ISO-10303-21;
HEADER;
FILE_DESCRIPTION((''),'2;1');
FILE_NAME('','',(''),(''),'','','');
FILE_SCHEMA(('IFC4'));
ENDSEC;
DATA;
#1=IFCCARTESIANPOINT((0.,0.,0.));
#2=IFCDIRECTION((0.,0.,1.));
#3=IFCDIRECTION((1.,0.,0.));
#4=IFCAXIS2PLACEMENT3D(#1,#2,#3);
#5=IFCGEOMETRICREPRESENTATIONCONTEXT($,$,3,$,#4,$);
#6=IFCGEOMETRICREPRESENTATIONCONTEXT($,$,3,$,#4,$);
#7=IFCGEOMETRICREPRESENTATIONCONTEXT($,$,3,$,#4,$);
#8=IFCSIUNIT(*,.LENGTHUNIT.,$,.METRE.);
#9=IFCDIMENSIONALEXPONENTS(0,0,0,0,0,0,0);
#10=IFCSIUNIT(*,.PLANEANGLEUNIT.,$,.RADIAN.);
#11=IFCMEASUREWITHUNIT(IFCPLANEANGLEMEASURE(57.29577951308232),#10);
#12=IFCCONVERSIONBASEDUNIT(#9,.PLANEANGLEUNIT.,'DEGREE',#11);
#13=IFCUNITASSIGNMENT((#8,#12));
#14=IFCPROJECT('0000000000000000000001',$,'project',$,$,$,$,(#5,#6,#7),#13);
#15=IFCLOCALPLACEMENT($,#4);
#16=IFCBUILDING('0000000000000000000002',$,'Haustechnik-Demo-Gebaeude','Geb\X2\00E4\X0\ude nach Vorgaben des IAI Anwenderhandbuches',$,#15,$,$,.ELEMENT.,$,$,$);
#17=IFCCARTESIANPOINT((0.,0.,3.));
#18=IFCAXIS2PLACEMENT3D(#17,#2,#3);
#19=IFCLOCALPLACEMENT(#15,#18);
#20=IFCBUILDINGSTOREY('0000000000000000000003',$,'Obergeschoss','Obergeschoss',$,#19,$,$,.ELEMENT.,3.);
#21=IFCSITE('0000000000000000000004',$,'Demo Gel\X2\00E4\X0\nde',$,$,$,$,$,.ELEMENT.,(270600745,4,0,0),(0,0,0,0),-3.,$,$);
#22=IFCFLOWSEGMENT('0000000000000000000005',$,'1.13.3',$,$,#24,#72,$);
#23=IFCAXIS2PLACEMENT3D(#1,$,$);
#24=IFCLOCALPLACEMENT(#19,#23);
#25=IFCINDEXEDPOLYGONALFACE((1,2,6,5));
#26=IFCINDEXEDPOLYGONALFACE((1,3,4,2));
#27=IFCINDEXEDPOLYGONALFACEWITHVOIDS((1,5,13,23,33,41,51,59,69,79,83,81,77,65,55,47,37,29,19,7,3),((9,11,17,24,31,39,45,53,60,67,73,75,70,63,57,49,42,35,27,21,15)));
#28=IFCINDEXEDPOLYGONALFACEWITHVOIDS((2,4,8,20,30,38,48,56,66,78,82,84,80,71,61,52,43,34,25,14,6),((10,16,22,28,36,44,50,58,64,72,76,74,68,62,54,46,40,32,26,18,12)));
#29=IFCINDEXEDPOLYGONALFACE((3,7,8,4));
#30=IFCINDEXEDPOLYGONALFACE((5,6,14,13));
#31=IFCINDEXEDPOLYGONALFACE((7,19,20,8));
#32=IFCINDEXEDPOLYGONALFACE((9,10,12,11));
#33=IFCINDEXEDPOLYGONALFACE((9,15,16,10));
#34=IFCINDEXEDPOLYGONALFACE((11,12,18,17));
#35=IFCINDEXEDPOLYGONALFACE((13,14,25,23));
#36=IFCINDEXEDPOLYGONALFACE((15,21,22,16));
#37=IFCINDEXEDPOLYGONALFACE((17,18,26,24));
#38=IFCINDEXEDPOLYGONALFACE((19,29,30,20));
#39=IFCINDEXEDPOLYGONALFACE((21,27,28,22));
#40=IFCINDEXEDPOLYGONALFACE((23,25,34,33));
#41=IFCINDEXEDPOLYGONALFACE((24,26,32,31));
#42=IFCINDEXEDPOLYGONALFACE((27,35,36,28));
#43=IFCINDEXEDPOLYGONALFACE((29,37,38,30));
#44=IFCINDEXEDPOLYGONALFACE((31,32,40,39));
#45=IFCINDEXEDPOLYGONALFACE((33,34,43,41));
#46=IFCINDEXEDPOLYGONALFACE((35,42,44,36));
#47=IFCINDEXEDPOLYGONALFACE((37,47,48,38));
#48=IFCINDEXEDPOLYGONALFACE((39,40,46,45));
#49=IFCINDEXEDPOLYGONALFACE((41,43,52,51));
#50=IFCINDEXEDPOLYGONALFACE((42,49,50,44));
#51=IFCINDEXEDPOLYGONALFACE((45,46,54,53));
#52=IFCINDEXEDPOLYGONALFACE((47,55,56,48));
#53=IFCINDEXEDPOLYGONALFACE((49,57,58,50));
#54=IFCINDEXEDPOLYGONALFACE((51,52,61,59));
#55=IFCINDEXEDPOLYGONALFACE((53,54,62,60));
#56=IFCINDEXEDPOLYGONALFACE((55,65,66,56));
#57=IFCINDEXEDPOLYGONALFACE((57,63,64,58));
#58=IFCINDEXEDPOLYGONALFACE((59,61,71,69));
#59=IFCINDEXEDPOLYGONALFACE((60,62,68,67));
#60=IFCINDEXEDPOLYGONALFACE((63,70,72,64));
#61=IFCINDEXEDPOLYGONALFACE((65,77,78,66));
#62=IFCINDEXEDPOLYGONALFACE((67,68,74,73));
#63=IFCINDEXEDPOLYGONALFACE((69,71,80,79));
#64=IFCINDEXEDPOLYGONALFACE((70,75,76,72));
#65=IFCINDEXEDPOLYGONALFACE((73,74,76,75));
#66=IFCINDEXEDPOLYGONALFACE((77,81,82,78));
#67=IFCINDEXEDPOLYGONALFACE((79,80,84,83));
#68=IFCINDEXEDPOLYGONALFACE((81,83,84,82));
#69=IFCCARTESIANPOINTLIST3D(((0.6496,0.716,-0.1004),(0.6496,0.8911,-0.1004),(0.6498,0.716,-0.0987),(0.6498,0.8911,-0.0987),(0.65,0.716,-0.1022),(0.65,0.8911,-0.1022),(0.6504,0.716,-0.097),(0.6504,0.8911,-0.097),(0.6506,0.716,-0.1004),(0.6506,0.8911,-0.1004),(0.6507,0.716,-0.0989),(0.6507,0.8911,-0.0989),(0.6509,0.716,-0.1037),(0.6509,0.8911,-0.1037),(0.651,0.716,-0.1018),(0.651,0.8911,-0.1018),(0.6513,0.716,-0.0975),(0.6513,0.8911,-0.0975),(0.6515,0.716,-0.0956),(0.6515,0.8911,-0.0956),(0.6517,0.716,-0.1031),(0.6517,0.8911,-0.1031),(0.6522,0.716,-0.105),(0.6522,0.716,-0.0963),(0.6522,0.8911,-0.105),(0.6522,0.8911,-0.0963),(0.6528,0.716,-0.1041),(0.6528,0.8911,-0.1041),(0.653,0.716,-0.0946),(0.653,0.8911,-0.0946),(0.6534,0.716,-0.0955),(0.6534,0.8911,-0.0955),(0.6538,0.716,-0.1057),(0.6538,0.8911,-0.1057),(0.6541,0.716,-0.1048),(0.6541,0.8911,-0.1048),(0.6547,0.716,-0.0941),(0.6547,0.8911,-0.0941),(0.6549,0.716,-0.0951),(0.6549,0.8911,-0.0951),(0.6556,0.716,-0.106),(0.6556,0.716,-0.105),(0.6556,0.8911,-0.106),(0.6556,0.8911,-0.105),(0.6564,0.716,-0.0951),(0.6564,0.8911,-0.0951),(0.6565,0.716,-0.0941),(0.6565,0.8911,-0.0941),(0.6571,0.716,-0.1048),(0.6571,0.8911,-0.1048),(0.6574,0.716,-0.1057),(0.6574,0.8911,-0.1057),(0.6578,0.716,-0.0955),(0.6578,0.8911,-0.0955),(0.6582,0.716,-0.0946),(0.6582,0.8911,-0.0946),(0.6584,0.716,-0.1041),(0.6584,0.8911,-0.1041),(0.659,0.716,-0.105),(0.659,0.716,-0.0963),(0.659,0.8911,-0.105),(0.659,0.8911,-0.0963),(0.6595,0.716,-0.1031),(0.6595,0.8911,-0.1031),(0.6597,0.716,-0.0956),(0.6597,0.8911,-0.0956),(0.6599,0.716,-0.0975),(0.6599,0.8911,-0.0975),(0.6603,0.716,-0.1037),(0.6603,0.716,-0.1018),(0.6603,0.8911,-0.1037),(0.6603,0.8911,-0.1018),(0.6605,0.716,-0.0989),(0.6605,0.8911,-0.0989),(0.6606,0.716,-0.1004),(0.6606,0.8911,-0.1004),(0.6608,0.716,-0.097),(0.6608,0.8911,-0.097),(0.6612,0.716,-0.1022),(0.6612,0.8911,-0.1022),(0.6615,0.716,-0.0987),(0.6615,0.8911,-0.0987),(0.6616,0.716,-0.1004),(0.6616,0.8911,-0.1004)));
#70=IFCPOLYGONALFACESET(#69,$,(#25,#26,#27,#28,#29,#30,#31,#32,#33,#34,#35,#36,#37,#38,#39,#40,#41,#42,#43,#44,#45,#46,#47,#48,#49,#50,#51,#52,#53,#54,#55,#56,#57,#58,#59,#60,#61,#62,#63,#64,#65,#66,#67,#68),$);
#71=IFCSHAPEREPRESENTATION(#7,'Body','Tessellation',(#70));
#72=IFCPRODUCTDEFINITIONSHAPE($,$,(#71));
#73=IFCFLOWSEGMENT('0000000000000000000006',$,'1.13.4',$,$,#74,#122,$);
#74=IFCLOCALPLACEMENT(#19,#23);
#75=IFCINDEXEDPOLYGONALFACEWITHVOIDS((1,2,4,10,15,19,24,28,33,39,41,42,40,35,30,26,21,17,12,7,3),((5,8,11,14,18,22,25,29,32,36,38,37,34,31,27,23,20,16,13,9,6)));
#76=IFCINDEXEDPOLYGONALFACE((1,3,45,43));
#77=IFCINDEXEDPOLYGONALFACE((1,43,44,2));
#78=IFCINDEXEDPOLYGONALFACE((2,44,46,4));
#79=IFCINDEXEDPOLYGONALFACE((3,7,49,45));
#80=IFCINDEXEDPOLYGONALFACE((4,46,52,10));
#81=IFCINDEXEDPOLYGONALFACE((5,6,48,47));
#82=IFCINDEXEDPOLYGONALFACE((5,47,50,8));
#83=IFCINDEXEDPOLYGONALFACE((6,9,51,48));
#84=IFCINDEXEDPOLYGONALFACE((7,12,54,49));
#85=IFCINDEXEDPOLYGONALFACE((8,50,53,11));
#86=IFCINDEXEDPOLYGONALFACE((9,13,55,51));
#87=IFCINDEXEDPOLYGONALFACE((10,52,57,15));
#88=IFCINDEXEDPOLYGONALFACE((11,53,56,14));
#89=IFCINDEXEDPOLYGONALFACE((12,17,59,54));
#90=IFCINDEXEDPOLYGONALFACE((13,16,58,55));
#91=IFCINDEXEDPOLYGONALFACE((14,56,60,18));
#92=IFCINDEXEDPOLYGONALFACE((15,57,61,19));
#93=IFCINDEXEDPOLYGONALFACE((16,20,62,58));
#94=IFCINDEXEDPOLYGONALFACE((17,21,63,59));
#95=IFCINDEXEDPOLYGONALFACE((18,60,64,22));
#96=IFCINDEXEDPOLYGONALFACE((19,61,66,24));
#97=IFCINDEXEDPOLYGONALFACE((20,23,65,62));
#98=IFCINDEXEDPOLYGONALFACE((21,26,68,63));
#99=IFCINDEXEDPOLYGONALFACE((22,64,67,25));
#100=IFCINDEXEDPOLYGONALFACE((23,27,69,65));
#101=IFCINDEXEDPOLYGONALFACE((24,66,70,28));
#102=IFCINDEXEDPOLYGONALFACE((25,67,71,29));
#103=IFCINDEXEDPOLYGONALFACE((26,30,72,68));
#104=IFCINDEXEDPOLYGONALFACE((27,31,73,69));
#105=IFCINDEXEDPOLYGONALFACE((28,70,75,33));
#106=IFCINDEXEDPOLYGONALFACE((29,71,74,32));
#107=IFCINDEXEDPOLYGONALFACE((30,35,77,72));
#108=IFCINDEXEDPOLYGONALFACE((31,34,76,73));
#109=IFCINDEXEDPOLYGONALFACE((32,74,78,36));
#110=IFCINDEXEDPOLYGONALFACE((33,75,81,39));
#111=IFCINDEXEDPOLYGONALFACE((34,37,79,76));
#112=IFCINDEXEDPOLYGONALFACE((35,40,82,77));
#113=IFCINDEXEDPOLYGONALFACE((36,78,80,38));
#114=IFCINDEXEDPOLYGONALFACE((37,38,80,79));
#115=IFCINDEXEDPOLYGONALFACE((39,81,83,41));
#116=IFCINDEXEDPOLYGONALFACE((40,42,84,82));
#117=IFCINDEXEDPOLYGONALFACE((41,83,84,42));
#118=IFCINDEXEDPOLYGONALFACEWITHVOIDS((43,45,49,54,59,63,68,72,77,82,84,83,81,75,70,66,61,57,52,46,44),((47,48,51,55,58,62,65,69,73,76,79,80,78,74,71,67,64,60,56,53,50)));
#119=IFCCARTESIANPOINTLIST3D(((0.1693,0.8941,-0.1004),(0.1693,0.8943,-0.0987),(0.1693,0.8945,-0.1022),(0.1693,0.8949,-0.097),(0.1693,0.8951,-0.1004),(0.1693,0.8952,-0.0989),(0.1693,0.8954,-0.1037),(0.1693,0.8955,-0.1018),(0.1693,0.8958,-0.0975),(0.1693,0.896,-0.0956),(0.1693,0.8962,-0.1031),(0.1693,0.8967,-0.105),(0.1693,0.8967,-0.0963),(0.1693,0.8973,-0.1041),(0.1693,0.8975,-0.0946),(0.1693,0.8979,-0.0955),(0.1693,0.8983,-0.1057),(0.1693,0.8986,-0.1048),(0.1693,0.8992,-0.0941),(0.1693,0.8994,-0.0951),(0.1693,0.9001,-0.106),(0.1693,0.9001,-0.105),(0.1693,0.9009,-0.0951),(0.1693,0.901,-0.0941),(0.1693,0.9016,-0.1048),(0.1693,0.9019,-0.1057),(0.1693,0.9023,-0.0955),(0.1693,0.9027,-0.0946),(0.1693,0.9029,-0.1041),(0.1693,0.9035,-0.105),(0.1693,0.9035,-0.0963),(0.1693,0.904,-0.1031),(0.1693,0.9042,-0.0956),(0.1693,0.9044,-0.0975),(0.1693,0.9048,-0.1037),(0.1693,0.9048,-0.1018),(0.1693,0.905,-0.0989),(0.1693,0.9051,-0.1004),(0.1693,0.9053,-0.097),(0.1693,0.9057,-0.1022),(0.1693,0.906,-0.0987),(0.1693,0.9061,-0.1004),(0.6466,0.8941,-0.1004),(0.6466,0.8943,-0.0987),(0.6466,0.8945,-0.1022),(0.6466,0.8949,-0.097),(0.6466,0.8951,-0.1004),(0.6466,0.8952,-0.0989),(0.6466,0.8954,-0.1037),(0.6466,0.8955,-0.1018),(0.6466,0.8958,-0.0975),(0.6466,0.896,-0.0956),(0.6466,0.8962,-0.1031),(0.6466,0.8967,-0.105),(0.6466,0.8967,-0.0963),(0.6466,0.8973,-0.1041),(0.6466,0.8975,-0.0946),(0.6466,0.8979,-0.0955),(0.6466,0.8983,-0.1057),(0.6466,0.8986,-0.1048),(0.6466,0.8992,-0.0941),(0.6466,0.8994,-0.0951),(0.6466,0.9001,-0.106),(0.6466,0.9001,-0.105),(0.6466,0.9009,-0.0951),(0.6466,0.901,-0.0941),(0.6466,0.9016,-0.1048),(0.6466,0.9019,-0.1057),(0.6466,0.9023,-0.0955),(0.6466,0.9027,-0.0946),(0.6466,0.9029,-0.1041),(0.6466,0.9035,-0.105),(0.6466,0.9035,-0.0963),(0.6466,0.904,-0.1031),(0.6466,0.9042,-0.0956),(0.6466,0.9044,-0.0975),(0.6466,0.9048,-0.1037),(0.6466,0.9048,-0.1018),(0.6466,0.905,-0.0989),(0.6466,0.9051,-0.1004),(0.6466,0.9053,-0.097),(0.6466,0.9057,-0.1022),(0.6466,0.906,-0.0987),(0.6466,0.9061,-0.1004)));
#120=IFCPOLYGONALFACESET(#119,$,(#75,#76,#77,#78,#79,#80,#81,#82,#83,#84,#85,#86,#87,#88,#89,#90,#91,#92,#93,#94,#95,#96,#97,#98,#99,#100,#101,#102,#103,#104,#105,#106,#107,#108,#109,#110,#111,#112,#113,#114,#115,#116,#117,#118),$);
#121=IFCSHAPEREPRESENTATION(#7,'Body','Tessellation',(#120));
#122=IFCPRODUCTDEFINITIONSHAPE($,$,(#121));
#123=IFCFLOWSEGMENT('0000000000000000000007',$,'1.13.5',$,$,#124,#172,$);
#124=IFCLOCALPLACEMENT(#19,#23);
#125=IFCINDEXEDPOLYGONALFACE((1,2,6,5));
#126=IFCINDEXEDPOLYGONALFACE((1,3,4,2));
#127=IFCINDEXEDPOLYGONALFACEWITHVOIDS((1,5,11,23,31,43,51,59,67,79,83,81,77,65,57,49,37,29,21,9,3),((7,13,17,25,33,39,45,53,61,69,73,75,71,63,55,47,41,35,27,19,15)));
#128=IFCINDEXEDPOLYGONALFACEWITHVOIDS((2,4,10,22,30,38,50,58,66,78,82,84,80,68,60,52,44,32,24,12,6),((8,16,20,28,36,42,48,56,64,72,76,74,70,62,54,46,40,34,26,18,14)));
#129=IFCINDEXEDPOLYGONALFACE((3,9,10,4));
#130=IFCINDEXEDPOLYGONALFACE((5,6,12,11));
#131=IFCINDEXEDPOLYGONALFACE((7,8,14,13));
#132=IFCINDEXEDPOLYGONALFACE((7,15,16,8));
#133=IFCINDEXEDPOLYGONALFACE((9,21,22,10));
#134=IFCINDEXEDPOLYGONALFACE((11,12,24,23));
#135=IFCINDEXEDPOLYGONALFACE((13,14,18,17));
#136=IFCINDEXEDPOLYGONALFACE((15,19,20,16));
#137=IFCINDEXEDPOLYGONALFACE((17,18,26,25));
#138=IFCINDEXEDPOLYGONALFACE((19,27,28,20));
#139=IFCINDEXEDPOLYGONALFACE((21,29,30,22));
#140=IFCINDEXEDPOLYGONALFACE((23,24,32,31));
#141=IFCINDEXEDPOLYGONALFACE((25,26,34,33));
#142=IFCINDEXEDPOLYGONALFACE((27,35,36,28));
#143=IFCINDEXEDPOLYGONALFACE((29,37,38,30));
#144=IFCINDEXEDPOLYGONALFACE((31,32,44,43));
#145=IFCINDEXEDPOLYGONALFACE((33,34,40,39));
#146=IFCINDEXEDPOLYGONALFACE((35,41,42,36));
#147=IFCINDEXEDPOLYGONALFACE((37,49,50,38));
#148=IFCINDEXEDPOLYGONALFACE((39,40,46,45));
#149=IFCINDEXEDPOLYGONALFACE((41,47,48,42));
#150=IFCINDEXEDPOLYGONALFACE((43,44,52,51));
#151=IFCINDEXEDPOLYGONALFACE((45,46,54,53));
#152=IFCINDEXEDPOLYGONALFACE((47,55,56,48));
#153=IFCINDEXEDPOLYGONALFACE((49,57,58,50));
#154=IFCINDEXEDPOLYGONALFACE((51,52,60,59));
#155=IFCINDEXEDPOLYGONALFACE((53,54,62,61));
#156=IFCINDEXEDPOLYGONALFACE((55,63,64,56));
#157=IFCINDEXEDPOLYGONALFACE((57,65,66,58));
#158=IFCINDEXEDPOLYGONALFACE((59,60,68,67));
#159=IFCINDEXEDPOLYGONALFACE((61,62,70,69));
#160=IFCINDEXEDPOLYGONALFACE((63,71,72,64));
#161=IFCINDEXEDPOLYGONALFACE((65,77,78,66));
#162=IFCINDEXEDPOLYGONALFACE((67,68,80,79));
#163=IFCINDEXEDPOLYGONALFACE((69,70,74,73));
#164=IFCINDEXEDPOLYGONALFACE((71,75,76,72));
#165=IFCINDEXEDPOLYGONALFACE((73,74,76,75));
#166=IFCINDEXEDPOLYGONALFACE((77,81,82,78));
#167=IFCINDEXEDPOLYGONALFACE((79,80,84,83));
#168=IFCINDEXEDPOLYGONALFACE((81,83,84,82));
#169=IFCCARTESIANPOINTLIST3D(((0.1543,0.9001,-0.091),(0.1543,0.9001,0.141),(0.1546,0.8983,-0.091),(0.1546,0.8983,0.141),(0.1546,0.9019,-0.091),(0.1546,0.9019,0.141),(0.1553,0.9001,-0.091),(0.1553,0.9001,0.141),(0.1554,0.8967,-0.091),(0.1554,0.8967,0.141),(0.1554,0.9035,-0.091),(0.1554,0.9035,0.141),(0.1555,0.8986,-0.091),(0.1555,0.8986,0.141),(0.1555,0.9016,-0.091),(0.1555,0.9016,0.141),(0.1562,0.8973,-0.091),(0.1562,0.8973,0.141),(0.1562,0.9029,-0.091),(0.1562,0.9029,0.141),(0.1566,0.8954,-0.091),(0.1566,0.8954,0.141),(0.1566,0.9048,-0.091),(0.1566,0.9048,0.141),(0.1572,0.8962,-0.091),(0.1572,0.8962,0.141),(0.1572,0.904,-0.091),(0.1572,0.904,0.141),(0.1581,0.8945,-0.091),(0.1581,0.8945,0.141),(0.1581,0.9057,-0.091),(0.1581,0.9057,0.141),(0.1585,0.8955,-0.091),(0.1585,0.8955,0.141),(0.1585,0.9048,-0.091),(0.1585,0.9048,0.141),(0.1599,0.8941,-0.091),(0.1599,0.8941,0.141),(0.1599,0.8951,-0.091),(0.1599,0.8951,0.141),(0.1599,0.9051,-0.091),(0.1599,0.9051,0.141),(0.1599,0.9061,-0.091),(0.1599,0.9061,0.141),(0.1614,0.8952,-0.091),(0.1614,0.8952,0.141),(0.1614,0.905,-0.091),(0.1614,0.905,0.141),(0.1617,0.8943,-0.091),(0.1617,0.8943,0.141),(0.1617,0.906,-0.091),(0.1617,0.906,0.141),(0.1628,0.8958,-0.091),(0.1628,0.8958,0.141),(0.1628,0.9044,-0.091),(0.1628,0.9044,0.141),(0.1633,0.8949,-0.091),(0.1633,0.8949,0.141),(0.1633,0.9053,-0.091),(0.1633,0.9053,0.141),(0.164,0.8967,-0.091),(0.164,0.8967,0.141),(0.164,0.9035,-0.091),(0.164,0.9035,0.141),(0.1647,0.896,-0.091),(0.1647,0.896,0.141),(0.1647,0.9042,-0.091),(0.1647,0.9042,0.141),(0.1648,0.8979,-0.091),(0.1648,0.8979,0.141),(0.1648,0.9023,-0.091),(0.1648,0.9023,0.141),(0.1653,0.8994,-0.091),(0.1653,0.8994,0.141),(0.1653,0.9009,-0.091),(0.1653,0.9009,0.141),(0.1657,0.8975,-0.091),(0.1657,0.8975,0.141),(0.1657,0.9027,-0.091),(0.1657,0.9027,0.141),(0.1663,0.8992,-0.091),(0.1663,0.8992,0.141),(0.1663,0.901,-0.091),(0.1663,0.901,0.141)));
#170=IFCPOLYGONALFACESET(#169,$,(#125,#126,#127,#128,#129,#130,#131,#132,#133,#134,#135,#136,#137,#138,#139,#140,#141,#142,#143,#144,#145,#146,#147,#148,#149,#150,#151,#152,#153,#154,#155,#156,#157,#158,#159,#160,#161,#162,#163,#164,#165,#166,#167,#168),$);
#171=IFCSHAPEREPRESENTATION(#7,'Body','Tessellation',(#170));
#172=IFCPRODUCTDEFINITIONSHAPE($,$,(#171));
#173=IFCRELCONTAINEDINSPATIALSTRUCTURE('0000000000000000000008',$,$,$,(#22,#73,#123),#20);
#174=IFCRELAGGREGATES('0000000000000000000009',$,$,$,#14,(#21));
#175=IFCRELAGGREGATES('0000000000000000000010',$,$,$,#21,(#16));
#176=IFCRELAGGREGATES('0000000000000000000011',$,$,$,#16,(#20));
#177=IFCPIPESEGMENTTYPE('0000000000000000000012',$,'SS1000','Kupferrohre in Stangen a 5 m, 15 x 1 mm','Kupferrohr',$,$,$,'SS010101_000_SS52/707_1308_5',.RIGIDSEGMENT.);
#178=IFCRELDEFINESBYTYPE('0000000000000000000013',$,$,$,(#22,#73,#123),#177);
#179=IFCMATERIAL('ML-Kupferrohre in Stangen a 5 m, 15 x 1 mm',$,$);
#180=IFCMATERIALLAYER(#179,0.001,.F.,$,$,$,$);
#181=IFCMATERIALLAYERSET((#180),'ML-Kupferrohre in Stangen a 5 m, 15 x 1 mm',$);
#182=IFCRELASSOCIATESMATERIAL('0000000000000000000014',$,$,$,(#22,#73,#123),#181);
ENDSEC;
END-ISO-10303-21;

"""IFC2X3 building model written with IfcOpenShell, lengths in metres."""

from ifc_helpers import new_model, entity, si_unit, converted_unit, frame, origin_with_axes, origin_2d_with_axis, place, context, project, spatial, hollow_circle, extrude, material, layer, layer_set, layer_usage, type_object, element, save


model = new_model("IFC2X3")

# Units and contexts
context_of_model_1 = context(None, 3, world=origin_with_axes())
context_of_model_2 = context(None, 3, world=origin_with_axes())
context_of_model_3 = context(None, 3, world=origin_with_axes())
ifc_project = project(units=[si_unit("LENGTHUNIT", "METRE"), converted_unit("PLANEANGLEUNIT", "DEGREE", entity("IfcPlaneAngleMeasure", 57.29577951308232), si_unit("PLANEANGLEUNIT", "RADIAN"), dimensions=[0, 0, 0, 0, 0, 0, 0])], contexts=[context_of_model_1, context_of_model_2, context_of_model_3])

# Site, building, storey
site = spatial("IfcSite", under=ifc_project, Name="Demo Gelände", CompositionType="ELEMENT", RefLatitude=(270600745, 4, 0, 0), RefLongitude=(0, 0, 0, 0), RefElevation=-3.0)
building_placement = place(None, origin_with_axes())
building = spatial("IfcBuilding", under=site, at=building_placement, Name="Haustechnik-Demo-Gebaeude", Description="Gebäude nach Vorgaben des IAI Anwenderhandbuches", CompositionType="ELEMENT")
storey_placement = place(building_placement, frame((0.0, 0.0, 3.0), z_axis=(0.0, 0.0, 1.0), x_axis=(1.0, 0.0, 0.0)))
storey = spatial("IfcBuildingStorey", under=building, at=storey_placement, Name="Obergeschoss", Description="Obergeschoss", CompositionType="ELEMENT", Elevation=3.0)

# Flow segments
ifc_material = material(Name="ML-Kupferrohre in Stangen a 5 m, 15 x 1 mm")
ifc_layer = layer(ifc_material, 0.001, ventilated=False)
ifc_layer_set = layer_set([ifc_layer], Name="ML-Kupferrohre in Stangen a 5 m, 15 x 1 mm")
ifc_layer_usage = layer_usage(ifc_layer_set, "AXIS2", "POSITIVE", 0.0)
pipe_segment_type_1 = type_object("IfcPipeSegmentType", Name="SS1000", Description="Kupferrohre in Stangen a 5 m, 15 x 1 mm", ApplicableOccurrence="Kupferrohr", ElementType="SS010101_000_SS52/707_1308_5", PredefinedType="RIGIDSEGMENT")
flow_segment_1_placement = place(storey_placement, frame((0.6556, 0.716, -0.1), z_axis=(0.0, 1.0, 0.0), x_axis=(0.0, 0.0, -1.0)))
element("IfcFlowSegment", 1, at=flow_segment_1_placement, inside=storey, type_object=pipe_segment_type_1, material=ifc_layer_usage, Name="1.13.3", context=context_of_model_3, shape_type="SweptSolid", body=[
    extrude(hollow_circle(Radius=0.006, WallThickness=0.001, at=origin_2d_with_axis()), origin_with_axes(), (0.0, 0.0, 1.0), 0.1751),
])
flow_segment_2_placement = place(storey_placement, frame((0.6466, 0.9001, -0.1), z_axis=(-1.0, 0.0, 0.0), x_axis=(0.0, 0.0, -1.0)))
element("IfcFlowSegment", 2, at=flow_segment_2_placement, inside=storey, type_object=pipe_segment_type_1, material=ifc_layer_usage, Name="1.13.4", context=context_of_model_3, shape_type="SweptSolid", body=[
    extrude(hollow_circle(Radius=0.006, WallThickness=0.001, at=origin_2d_with_axis()), origin_with_axes(), (0.0, 0.0, 1.0), 0.4773),
])
flow_segment_3_placement = place(storey_placement, frame((0.1603, 0.9001, -0.091), z_axis=(0.0, 0.0, 1.0), x_axis=(-1.0, 0.0, 0.0)))
element("IfcFlowSegment", 3, at=flow_segment_3_placement, inside=storey, type_object=pipe_segment_type_1, material=ifc_layer_usage, Name="1.13.5", context=context_of_model_3, shape_type="SweptSolid", body=[
    extrude(hollow_circle(Radius=0.006, WallThickness=0.001, at=origin_2d_with_axis()), origin_with_axes(), (0.0, 0.0, 1.0), 0.232),
])

save(model, "model.ifc")
